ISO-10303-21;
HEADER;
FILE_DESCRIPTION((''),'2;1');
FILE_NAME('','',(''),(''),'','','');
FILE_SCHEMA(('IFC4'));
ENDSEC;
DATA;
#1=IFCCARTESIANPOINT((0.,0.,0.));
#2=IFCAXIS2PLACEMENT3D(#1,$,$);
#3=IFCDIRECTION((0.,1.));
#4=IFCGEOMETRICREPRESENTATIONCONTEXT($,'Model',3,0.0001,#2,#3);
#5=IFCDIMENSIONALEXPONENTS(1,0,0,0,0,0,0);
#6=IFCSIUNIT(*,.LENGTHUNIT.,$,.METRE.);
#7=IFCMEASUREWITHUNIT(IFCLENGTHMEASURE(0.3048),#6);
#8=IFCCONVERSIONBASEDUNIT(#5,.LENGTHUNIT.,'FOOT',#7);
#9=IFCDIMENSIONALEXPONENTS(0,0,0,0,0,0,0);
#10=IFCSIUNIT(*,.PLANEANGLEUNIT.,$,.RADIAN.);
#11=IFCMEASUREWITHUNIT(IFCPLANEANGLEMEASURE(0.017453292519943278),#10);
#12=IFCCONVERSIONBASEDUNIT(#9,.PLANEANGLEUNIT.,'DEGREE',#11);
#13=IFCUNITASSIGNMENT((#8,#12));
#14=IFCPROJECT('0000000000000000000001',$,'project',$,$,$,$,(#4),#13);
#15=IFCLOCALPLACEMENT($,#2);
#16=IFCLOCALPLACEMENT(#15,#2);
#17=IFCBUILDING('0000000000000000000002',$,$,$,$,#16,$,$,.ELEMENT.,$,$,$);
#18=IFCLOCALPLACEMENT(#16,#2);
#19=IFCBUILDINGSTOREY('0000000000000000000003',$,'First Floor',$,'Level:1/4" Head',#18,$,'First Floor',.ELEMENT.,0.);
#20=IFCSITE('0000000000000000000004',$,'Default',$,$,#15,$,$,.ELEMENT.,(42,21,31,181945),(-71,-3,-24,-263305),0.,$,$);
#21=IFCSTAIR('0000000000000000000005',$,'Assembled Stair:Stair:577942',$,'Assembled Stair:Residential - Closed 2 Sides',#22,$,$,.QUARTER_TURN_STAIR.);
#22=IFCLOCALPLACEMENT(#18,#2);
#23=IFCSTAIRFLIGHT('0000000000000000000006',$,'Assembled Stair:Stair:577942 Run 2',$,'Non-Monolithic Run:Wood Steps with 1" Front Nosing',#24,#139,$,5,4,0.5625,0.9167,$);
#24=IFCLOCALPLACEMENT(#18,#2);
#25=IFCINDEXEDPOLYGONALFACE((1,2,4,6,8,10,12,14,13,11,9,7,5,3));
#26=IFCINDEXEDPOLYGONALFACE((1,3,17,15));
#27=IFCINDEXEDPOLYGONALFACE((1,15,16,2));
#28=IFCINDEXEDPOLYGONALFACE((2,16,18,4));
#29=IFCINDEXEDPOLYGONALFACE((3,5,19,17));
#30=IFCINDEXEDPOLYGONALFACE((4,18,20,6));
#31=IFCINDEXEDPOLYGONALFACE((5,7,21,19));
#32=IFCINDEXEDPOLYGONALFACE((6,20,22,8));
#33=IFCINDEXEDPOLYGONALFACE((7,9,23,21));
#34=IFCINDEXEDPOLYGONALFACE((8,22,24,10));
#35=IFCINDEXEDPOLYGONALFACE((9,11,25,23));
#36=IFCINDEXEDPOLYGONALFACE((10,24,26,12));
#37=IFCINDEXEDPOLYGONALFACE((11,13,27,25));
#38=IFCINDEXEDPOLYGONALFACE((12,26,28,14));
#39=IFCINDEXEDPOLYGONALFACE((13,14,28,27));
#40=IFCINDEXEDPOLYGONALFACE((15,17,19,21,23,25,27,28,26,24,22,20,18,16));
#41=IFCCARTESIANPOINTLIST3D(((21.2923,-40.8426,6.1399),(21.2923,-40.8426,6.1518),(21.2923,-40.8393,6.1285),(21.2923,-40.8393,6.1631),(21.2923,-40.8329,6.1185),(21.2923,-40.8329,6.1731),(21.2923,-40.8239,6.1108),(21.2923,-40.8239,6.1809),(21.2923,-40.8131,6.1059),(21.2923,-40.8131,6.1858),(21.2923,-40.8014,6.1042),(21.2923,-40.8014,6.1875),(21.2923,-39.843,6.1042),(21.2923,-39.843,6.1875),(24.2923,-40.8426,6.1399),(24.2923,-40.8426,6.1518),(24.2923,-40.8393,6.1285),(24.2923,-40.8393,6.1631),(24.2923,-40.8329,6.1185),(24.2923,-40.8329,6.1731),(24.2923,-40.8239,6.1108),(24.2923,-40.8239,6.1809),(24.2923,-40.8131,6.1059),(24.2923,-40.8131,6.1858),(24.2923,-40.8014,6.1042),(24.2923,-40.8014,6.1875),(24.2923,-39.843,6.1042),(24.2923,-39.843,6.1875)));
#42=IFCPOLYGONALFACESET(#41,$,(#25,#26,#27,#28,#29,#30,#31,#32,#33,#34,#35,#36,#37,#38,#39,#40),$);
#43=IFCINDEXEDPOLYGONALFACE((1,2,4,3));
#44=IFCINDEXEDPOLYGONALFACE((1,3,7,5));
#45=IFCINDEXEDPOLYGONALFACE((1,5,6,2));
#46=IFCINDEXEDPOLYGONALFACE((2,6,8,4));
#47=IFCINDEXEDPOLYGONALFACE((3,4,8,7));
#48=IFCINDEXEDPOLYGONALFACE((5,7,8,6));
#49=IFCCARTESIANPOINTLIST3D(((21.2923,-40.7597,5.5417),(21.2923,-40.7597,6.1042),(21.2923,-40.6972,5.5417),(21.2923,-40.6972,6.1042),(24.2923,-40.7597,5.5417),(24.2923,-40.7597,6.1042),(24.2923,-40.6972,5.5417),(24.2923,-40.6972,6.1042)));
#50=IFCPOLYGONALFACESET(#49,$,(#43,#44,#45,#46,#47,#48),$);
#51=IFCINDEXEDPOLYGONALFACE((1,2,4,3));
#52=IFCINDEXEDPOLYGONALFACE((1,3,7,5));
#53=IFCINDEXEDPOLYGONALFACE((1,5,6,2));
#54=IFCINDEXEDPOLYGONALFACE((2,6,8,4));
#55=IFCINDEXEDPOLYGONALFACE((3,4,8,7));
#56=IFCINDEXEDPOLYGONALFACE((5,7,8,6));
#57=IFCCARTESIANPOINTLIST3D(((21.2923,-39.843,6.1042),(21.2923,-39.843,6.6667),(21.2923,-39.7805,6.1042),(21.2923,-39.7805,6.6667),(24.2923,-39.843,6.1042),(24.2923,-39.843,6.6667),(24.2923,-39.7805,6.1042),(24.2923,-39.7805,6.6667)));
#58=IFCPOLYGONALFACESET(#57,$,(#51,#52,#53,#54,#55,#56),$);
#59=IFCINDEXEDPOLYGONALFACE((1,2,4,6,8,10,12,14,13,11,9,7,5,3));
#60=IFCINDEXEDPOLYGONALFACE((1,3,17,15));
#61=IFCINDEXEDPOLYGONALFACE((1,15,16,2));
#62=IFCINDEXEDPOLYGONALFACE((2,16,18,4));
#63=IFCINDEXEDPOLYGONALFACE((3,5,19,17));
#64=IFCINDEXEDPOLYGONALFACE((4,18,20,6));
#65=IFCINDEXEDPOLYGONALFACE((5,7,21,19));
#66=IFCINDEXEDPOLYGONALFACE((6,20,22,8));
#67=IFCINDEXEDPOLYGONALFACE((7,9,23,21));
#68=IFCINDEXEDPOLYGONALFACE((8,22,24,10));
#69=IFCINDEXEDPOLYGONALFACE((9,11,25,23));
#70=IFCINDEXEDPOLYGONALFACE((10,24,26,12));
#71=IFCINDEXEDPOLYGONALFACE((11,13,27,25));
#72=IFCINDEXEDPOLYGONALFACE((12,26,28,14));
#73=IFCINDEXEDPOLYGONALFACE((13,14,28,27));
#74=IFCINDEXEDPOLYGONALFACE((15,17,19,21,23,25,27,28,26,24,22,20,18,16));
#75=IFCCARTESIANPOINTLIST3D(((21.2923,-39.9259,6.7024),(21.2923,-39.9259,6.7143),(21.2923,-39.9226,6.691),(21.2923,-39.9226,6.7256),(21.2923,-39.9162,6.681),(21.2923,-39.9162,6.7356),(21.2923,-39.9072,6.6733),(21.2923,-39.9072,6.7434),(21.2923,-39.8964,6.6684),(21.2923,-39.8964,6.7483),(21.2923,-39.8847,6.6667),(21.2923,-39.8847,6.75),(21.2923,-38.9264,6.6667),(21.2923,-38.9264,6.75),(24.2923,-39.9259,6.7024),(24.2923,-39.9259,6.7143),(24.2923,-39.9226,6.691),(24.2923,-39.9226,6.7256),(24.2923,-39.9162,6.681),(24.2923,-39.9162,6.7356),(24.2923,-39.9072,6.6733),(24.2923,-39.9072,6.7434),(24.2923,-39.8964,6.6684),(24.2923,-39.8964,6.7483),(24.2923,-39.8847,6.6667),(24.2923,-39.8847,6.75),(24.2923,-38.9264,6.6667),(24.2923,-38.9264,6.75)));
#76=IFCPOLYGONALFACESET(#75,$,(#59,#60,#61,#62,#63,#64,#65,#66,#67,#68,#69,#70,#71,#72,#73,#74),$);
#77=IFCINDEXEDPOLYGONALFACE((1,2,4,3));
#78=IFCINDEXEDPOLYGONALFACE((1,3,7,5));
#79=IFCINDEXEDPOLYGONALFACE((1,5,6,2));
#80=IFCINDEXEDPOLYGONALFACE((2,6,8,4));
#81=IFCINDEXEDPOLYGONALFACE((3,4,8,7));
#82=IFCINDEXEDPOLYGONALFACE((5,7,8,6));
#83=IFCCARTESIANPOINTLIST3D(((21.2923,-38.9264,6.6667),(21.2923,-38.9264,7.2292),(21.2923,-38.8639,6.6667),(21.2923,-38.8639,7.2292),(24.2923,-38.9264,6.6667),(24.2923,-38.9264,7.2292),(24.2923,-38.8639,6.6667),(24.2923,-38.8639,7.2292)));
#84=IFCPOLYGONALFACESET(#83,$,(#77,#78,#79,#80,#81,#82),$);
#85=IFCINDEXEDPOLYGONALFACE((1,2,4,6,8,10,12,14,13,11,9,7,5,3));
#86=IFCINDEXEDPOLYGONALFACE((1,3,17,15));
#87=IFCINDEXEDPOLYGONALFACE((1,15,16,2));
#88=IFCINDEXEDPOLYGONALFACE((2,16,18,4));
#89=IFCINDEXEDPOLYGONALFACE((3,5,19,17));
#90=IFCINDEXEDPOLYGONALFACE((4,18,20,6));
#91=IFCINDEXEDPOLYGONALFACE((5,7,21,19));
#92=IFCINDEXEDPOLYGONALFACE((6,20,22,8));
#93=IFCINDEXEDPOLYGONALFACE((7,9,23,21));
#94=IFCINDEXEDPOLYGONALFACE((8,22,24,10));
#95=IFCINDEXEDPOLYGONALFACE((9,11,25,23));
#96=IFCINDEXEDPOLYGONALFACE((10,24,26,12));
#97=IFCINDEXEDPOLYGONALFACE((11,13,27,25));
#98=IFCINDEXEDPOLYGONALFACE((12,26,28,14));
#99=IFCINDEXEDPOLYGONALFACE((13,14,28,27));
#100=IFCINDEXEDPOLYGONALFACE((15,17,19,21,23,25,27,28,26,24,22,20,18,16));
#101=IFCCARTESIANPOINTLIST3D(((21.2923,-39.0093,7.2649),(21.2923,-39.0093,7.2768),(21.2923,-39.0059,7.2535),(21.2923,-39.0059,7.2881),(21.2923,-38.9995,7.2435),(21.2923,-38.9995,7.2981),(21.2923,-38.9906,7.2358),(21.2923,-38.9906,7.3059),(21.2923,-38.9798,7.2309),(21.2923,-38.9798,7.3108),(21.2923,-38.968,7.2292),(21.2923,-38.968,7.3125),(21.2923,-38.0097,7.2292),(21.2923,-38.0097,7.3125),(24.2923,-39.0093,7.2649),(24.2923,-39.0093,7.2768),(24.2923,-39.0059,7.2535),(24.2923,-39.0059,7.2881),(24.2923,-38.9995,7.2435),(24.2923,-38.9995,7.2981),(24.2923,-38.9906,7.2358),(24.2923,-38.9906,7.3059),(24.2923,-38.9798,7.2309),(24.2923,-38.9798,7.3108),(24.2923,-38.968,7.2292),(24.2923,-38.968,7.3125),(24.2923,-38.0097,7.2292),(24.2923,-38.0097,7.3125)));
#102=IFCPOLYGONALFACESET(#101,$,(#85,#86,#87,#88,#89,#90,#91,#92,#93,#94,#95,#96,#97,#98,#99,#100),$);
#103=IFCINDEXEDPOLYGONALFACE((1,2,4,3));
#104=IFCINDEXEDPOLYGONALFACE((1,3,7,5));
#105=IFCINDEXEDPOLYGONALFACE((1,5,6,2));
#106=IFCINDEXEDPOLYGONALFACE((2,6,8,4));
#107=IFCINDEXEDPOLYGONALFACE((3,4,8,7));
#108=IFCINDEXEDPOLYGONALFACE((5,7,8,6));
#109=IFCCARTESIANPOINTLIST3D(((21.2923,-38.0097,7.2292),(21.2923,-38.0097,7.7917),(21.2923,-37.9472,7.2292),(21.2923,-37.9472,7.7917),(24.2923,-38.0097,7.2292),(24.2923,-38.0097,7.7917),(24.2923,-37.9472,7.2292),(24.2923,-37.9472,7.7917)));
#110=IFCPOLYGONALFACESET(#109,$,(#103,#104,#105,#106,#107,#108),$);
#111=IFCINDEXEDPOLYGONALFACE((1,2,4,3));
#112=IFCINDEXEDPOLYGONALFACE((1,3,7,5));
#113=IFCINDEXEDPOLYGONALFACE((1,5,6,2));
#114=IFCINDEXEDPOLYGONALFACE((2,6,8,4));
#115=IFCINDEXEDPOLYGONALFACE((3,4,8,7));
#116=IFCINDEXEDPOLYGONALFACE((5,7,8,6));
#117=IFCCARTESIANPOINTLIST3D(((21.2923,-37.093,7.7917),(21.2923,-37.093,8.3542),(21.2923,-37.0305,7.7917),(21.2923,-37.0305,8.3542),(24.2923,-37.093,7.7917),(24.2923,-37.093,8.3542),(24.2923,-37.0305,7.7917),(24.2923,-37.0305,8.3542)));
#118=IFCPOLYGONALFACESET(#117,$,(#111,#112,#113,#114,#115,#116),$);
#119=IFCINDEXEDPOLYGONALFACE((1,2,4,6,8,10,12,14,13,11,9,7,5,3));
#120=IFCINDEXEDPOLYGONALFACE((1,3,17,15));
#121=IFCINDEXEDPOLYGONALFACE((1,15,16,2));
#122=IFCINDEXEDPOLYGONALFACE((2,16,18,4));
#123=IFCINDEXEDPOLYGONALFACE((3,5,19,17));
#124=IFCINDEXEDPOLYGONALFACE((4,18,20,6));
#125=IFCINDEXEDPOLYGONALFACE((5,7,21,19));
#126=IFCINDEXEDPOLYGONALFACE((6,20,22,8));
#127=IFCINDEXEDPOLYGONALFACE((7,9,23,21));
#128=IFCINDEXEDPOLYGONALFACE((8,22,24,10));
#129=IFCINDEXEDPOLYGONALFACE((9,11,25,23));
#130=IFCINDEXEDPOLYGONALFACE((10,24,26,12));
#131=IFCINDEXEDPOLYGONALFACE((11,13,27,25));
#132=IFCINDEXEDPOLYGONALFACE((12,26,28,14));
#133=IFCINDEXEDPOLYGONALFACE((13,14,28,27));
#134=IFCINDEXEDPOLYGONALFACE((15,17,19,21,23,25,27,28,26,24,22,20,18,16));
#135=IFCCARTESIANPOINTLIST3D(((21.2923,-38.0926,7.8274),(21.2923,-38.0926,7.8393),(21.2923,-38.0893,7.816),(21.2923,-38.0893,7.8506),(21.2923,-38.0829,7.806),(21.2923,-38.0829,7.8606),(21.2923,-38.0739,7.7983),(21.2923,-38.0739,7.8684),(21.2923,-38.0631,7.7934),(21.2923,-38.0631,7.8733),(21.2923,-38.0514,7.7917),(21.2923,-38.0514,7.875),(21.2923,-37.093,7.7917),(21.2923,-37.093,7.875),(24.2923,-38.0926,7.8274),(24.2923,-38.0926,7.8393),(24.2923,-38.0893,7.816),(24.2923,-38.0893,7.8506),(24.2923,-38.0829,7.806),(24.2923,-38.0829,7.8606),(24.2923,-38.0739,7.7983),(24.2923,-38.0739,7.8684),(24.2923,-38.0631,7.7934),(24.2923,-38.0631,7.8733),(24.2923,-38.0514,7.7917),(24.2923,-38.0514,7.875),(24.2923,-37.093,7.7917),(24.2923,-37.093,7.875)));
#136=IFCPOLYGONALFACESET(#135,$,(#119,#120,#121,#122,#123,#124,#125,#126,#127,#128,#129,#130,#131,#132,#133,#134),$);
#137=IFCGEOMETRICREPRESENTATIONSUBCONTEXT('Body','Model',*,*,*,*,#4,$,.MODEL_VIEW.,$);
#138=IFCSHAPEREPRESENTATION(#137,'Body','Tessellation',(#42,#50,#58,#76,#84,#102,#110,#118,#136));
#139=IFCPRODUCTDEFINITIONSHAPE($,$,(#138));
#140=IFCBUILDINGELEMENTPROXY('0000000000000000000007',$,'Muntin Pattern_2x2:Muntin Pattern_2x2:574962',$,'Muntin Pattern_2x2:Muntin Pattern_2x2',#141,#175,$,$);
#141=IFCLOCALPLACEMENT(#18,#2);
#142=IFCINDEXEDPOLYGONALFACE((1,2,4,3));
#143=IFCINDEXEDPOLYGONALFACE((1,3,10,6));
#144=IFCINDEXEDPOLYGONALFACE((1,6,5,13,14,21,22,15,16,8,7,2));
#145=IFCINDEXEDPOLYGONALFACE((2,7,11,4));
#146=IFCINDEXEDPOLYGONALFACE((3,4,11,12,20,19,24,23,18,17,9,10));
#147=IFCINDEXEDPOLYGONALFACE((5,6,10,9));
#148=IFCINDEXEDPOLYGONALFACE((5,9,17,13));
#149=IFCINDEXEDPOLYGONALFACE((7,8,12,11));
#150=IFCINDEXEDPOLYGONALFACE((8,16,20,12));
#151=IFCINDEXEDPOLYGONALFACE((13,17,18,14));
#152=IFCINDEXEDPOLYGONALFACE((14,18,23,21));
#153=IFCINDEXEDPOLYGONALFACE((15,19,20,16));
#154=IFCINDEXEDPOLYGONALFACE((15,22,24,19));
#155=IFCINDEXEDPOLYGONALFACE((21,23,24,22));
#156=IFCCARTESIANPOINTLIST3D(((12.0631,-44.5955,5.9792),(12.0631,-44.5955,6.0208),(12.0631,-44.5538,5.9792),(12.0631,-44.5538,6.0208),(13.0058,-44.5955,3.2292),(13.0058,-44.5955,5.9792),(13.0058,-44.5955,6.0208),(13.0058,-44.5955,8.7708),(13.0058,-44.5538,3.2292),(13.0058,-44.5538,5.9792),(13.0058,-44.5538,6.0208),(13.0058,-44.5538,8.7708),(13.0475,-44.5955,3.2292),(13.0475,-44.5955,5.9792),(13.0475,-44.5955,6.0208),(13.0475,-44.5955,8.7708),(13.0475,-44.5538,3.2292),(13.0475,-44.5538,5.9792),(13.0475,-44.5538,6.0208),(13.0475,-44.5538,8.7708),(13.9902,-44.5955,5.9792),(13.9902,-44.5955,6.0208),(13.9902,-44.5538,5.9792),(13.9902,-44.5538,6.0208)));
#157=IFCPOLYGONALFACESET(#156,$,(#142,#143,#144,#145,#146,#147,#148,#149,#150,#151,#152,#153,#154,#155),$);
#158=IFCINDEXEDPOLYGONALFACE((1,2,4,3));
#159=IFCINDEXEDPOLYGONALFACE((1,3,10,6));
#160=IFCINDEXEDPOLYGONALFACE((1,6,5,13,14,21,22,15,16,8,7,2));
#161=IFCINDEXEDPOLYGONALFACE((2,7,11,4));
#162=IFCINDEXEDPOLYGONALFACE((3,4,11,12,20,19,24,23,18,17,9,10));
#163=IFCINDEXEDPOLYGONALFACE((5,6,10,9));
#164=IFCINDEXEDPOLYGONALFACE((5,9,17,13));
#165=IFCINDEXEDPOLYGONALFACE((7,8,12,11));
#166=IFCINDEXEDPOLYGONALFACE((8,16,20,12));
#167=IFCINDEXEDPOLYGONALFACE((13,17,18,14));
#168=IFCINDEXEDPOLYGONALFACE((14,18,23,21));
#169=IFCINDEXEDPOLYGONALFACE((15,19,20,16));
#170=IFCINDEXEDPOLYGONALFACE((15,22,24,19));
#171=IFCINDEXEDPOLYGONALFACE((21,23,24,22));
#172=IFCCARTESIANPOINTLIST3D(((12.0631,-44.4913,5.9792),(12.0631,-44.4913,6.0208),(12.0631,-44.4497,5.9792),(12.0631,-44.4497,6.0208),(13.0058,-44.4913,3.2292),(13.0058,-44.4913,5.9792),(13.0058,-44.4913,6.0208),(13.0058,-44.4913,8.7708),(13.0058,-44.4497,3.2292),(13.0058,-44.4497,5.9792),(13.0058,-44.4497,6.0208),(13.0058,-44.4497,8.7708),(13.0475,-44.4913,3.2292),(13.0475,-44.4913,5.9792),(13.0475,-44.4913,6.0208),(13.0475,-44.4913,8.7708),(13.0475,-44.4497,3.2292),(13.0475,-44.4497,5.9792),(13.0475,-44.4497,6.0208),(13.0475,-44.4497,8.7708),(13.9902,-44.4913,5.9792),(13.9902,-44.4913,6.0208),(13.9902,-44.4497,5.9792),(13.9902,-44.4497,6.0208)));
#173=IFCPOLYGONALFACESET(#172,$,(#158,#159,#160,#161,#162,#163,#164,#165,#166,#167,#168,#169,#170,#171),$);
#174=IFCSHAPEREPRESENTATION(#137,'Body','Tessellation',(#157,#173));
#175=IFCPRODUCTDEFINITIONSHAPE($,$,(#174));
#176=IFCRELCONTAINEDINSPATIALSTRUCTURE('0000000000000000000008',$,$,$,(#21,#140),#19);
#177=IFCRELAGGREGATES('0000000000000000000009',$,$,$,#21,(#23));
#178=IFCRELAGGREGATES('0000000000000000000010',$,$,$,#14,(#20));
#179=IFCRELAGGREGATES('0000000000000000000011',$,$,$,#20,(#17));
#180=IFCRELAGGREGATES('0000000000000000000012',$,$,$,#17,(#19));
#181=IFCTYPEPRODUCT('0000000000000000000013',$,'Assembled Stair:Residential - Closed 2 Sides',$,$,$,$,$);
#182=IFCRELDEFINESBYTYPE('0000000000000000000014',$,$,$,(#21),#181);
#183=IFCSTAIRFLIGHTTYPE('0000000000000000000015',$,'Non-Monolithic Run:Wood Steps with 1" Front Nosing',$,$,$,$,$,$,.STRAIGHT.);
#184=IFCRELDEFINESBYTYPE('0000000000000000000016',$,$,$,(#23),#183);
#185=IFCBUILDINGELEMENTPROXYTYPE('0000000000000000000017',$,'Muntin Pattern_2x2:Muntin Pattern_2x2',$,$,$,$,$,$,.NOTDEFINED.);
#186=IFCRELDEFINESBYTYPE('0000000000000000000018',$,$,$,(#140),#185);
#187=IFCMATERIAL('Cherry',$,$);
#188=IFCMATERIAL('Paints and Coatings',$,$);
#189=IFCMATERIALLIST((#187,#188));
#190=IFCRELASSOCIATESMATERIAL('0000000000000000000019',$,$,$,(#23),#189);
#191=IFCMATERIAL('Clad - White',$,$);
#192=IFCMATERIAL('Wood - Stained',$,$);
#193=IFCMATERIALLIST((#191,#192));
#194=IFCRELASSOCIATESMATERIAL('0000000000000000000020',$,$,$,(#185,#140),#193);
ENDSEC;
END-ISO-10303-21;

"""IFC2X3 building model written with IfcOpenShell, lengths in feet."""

from ifc_helpers import new_model, entity, si_unit, converted_unit, direction, frame, frame_2d, origin, origin_2d_with_axis, place, context, subcontext, project, spatial, polyline, circle_curve, parameter, trimmed, segment, composite_curve, rectangle, outline, extrude, source, transform, mapped, material, material_list, type_object, type_shapes, element, aggregate, save


model = new_model("IFC2X3")

# Units and contexts
model_context = context("Model", 3, precision=0.0001, world=origin(), true_north=direction((0.0, 1.0)))
body_context = subcontext(model_context, "Body", "Model", "MODEL_VIEW")
ifc_project = project(units=[converted_unit("LENGTHUNIT", "FOOT", entity("IfcLengthMeasure", 0.3048), si_unit("LENGTHUNIT", "METRE"), dimensions=[1, 0, 0, 0, 0, 0, 0]), converted_unit("PLANEANGLEUNIT", "DEGREE", entity("IfcPlaneAngleMeasure", 0.017453292519943278), si_unit("PLANEANGLEUNIT", "RADIAN"), dimensions=[0, 0, 0, 0, 0, 0, 0])], contexts=[model_context])

# Site, building, storey
site_placement = place(None, origin())
site = spatial("IfcSite", under=ifc_project, at=site_placement, Name="Default", CompositionType="ELEMENT", RefLatitude=(42, 21, 31, 181945), RefLongitude=(-71, -3, -24, -263305), RefElevation=0.0)
building_placement = place(site_placement, origin())
building = spatial("IfcBuilding", under=site, at=building_placement, CompositionType="ELEMENT")
storey_placement = place(building_placement, origin())
storey = spatial("IfcBuildingStorey", under=building, at=storey_placement, Name="First Floor", ObjectType="Level:1/4\" Head", LongName="First Floor", CompositionType="ELEMENT", Elevation=0.0)

# Stair
type_product = type_object("IfcTypeProduct", Name="Assembled Stair:Residential - Closed 2 Sides")
stair_placement = place(storey_placement, origin())
stair = element("IfcStair", 1, at=stair_placement, inside=storey, type_object=type_product, Name="Assembled Stair:Stair:577942", ObjectType="Assembled Stair:Residential - Closed 2 Sides", ShapeType="QUARTER_TURN_STAIR")
ifc_material_1 = material(Name="Paints and Coatings")

# Stair flight
ifc_material_2 = material(Name="Cherry")
ifc_material_list_1 = material_list([ifc_material_2, ifc_material_1])
stair_flight_type = type_object("IfcStairFlightType", Name="Non-Monolithic Run:Wood Steps with 1\" Front Nosing", PredefinedType="STRAIGHT")
stair_flight_placement = place(stair_placement, frame((21.2923, -40.8483, 0.0)))
stair_flight = element("IfcStairFlight", 2, at=stair_flight_placement, type_object=stair_flight_type, material=ifc_material_list_1, Name="Assembled Stair:Stair:577942 Run 2", ObjectType="Non-Monolithic Run:Wood Steps with 1\" Front Nosing", NumberOfRiser=5, NumberOfTreads=4, RiserHeight=0.5625, TreadLength=0.9167, context=body_context, shape_type="SweptSolid", body=[
    extrude(outline(composite_curve([segment(trimmed(circle_curve(frame_2d((-0.4792, 0.0), x_axis=(1.0, 0.0)), 0.0417), [parameter(90.0)], [parameter(270.0)], True, "PARAMETER"), True, "CONTINUOUS"), segment(polyline([(-0.4792, -0.0417), (0.4792, -0.0417)]), True, "CONTINUOUS"), segment(polyline([(0.4792, -0.0417), (0.4792, 0.0417)]), True, "CONTINUOUS"), segment(polyline([(0.4792, 0.0417), (-0.4792, 0.0417)]), True, "CONTINUOUS")], self_intersect=False)), frame((0.0, 0.5261, 6.1458), z_axis=(1.0, 0.0, 0.0), x_axis=(0.0, 1.0, 0.0)), (0.0, 0.0, 1.0), 3.0),
    extrude(rectangle(XDim=3.0, YDim=0.0625, at=origin_2d_with_axis()), frame((1.5, 0.1198, 5.5417), z_axis=(0.0, 0.0, 1.0), x_axis=(-1.0, 0.0, 0.0)), (0.0, 0.0, 1.0), 0.5625),
    extrude(rectangle(XDim=3.0, YDim=0.0625, at=origin_2d_with_axis()), frame((1.5, 1.0365, 6.1042), z_axis=(0.0, 0.0, 1.0), x_axis=(-1.0, 0.0, 0.0)), (0.0, 0.0, 1.0), 0.5625),
    extrude(outline(composite_curve([segment(trimmed(circle_curve(frame_2d((-0.4792, 0.0), x_axis=(1.0, 0.0)), 0.0417), [parameter(90.0)], [parameter(270.0)], True, "PARAMETER"), True, "CONTINUOUS"), segment(polyline([(-0.4792, -0.0417), (0.4792, -0.0417)]), True, "CONTINUOUS"), segment(polyline([(0.4792, -0.0417), (0.4792, 0.0417)]), True, "CONTINUOUS"), segment(polyline([(0.4792, 0.0417), (-0.4792, 0.0417)]), True, "CONTINUOUS")], self_intersect=False)), frame((0.0, 1.4427, 6.7083), z_axis=(1.0, 0.0, 0.0), x_axis=(0.0, 1.0, 0.0)), (0.0, 0.0, 1.0), 3.0),
    extrude(rectangle(XDim=3.0, YDim=0.0625, at=origin_2d_with_axis()), frame((1.5, 1.9532, 6.6667), z_axis=(0.0, 0.0, 1.0), x_axis=(-1.0, 0.0, 0.0)), (0.0, 0.0, 1.0), 0.5625),
    extrude(outline(composite_curve([segment(trimmed(circle_curve(frame_2d((-0.4792, 0.0), x_axis=(1.0, 0.0)), 0.0417), [parameter(90.0)], [parameter(270.0)], True, "PARAMETER"), True, "CONTINUOUS"), segment(polyline([(-0.4792, -0.0417), (0.4792, -0.0417)]), True, "CONTINUOUS"), segment(polyline([(0.4792, -0.0417), (0.4792, 0.0417)]), True, "CONTINUOUS"), segment(polyline([(0.4792, 0.0417), (-0.4792, 0.0417)]), True, "CONTINUOUS")], self_intersect=False)), frame((0.0, 2.3594, 7.2708), z_axis=(1.0, 0.0, 0.0), x_axis=(0.0, 1.0, 0.0)), (0.0, 0.0, 1.0), 3.0),
    extrude(rectangle(XDim=3.0, YDim=0.0625, at=origin_2d_with_axis()), frame((1.5, 2.8698, 7.2292), z_axis=(0.0, 0.0, 1.0), x_axis=(-1.0, 0.0, 0.0)), (0.0, 0.0, 1.0), 0.5625),
    extrude(rectangle(XDim=3.0, YDim=0.0625, at=origin_2d_with_axis()), frame((1.5, 3.7865, 7.7917), z_axis=(0.0, 0.0, 1.0), x_axis=(-1.0, 0.0, 0.0)), (0.0, 0.0, 1.0), 0.5625),
    extrude(outline(composite_curve([segment(trimmed(circle_curve(frame_2d((-0.4792, 0.0), x_axis=(1.0, 0.0)), 0.0417), [parameter(90.0)], [parameter(270.0)], True, "PARAMETER"), True, "CONTINUOUS"), segment(polyline([(-0.4792, -0.0417), (0.4792, -0.0417)]), True, "CONTINUOUS"), segment(polyline([(0.4792, -0.0417), (0.4792, 0.0417)]), True, "CONTINUOUS"), segment(polyline([(0.4792, 0.0417), (-0.4792, 0.0417)]), True, "CONTINUOUS")], self_intersect=False)), frame((0.0, 3.2761, 7.8333), z_axis=(1.0, 0.0, 0.0), x_axis=(0.0, 1.0, 0.0)), (0.0, 0.0, 1.0), 3.0),
])
aggregate(stair, [stair_flight])

# Building element proxy
ifc_material_3 = material(Name="Clad - White")
ifc_material_4 = material(Name="Wood - Stained")
ifc_material_list_2 = material_list([ifc_material_3, ifc_material_4])
building_element_proxy_type_1 = type_object("IfcBuildingElementProxyType", Name="Muntin Pattern_2x2:Muntin Pattern_2x2", PredefinedType="NOTDEFINED", material=ifc_material_list_2)
shared_shape_1 = source(origin(), body_context, "Body", "SweptSolid", [
    extrude(outline(polyline([(0.0208, -0.0208), (2.7708, -0.0208), (2.7708, 0.0208), (0.0208, 0.0208), (0.0208, 0.9635), (-0.0208, 0.9635), (-0.0208, 0.0208), (-2.7708, 0.0208), (-2.7708, -0.0208), (-0.0208, -0.0208), (-0.0208, -0.9635), (0.0208, -0.9635), (0.0208, -0.0208)])), frame((0.0, -0.0729, 2.7708), z_axis=(0.0, 1.0, 0.0), x_axis=(0.0, 0.0, 1.0)), (0.0, 0.0, 1.0), 0.0417),
    extrude(outline(polyline([(0.0208, -0.0208), (2.7708, -0.0208), (2.7708, 0.0208), (0.0208, 0.0208), (0.0208, 0.9635), (-0.0208, 0.9635), (-0.0208, 0.0208), (-2.7708, 0.0208), (-2.7708, -0.0208), (-0.0208, -0.0208), (-0.0208, -0.9635), (0.0208, -0.9635), (0.0208, -0.0208)])), frame((0.0, 0.0313, 2.7708), z_axis=(0.0, 1.0, 0.0), x_axis=(0.0, 0.0, 1.0)), (0.0, 0.0, 1.0), 0.0417),
])
type_shapes(building_element_proxy_type_1, [shared_shape_1])
proxy_1_placement = place(storey_placement, frame((13.0266, -44.5226, 3.2292)))
element("IfcBuildingElementProxy", 3, at=proxy_1_placement, inside=storey, type_object=building_element_proxy_type_1, material=ifc_material_list_2, Name="Muntin Pattern_2x2:Muntin Pattern_2x2:574962", ObjectType="Muntin Pattern_2x2:Muntin Pattern_2x2", context=body_context, shape_type="MappedRepresentation", body=[
    mapped(shared_shape_1, transform((0.0, 0.0, 0.0), scale=1.0)),
])

save(model, "model.ifc")
